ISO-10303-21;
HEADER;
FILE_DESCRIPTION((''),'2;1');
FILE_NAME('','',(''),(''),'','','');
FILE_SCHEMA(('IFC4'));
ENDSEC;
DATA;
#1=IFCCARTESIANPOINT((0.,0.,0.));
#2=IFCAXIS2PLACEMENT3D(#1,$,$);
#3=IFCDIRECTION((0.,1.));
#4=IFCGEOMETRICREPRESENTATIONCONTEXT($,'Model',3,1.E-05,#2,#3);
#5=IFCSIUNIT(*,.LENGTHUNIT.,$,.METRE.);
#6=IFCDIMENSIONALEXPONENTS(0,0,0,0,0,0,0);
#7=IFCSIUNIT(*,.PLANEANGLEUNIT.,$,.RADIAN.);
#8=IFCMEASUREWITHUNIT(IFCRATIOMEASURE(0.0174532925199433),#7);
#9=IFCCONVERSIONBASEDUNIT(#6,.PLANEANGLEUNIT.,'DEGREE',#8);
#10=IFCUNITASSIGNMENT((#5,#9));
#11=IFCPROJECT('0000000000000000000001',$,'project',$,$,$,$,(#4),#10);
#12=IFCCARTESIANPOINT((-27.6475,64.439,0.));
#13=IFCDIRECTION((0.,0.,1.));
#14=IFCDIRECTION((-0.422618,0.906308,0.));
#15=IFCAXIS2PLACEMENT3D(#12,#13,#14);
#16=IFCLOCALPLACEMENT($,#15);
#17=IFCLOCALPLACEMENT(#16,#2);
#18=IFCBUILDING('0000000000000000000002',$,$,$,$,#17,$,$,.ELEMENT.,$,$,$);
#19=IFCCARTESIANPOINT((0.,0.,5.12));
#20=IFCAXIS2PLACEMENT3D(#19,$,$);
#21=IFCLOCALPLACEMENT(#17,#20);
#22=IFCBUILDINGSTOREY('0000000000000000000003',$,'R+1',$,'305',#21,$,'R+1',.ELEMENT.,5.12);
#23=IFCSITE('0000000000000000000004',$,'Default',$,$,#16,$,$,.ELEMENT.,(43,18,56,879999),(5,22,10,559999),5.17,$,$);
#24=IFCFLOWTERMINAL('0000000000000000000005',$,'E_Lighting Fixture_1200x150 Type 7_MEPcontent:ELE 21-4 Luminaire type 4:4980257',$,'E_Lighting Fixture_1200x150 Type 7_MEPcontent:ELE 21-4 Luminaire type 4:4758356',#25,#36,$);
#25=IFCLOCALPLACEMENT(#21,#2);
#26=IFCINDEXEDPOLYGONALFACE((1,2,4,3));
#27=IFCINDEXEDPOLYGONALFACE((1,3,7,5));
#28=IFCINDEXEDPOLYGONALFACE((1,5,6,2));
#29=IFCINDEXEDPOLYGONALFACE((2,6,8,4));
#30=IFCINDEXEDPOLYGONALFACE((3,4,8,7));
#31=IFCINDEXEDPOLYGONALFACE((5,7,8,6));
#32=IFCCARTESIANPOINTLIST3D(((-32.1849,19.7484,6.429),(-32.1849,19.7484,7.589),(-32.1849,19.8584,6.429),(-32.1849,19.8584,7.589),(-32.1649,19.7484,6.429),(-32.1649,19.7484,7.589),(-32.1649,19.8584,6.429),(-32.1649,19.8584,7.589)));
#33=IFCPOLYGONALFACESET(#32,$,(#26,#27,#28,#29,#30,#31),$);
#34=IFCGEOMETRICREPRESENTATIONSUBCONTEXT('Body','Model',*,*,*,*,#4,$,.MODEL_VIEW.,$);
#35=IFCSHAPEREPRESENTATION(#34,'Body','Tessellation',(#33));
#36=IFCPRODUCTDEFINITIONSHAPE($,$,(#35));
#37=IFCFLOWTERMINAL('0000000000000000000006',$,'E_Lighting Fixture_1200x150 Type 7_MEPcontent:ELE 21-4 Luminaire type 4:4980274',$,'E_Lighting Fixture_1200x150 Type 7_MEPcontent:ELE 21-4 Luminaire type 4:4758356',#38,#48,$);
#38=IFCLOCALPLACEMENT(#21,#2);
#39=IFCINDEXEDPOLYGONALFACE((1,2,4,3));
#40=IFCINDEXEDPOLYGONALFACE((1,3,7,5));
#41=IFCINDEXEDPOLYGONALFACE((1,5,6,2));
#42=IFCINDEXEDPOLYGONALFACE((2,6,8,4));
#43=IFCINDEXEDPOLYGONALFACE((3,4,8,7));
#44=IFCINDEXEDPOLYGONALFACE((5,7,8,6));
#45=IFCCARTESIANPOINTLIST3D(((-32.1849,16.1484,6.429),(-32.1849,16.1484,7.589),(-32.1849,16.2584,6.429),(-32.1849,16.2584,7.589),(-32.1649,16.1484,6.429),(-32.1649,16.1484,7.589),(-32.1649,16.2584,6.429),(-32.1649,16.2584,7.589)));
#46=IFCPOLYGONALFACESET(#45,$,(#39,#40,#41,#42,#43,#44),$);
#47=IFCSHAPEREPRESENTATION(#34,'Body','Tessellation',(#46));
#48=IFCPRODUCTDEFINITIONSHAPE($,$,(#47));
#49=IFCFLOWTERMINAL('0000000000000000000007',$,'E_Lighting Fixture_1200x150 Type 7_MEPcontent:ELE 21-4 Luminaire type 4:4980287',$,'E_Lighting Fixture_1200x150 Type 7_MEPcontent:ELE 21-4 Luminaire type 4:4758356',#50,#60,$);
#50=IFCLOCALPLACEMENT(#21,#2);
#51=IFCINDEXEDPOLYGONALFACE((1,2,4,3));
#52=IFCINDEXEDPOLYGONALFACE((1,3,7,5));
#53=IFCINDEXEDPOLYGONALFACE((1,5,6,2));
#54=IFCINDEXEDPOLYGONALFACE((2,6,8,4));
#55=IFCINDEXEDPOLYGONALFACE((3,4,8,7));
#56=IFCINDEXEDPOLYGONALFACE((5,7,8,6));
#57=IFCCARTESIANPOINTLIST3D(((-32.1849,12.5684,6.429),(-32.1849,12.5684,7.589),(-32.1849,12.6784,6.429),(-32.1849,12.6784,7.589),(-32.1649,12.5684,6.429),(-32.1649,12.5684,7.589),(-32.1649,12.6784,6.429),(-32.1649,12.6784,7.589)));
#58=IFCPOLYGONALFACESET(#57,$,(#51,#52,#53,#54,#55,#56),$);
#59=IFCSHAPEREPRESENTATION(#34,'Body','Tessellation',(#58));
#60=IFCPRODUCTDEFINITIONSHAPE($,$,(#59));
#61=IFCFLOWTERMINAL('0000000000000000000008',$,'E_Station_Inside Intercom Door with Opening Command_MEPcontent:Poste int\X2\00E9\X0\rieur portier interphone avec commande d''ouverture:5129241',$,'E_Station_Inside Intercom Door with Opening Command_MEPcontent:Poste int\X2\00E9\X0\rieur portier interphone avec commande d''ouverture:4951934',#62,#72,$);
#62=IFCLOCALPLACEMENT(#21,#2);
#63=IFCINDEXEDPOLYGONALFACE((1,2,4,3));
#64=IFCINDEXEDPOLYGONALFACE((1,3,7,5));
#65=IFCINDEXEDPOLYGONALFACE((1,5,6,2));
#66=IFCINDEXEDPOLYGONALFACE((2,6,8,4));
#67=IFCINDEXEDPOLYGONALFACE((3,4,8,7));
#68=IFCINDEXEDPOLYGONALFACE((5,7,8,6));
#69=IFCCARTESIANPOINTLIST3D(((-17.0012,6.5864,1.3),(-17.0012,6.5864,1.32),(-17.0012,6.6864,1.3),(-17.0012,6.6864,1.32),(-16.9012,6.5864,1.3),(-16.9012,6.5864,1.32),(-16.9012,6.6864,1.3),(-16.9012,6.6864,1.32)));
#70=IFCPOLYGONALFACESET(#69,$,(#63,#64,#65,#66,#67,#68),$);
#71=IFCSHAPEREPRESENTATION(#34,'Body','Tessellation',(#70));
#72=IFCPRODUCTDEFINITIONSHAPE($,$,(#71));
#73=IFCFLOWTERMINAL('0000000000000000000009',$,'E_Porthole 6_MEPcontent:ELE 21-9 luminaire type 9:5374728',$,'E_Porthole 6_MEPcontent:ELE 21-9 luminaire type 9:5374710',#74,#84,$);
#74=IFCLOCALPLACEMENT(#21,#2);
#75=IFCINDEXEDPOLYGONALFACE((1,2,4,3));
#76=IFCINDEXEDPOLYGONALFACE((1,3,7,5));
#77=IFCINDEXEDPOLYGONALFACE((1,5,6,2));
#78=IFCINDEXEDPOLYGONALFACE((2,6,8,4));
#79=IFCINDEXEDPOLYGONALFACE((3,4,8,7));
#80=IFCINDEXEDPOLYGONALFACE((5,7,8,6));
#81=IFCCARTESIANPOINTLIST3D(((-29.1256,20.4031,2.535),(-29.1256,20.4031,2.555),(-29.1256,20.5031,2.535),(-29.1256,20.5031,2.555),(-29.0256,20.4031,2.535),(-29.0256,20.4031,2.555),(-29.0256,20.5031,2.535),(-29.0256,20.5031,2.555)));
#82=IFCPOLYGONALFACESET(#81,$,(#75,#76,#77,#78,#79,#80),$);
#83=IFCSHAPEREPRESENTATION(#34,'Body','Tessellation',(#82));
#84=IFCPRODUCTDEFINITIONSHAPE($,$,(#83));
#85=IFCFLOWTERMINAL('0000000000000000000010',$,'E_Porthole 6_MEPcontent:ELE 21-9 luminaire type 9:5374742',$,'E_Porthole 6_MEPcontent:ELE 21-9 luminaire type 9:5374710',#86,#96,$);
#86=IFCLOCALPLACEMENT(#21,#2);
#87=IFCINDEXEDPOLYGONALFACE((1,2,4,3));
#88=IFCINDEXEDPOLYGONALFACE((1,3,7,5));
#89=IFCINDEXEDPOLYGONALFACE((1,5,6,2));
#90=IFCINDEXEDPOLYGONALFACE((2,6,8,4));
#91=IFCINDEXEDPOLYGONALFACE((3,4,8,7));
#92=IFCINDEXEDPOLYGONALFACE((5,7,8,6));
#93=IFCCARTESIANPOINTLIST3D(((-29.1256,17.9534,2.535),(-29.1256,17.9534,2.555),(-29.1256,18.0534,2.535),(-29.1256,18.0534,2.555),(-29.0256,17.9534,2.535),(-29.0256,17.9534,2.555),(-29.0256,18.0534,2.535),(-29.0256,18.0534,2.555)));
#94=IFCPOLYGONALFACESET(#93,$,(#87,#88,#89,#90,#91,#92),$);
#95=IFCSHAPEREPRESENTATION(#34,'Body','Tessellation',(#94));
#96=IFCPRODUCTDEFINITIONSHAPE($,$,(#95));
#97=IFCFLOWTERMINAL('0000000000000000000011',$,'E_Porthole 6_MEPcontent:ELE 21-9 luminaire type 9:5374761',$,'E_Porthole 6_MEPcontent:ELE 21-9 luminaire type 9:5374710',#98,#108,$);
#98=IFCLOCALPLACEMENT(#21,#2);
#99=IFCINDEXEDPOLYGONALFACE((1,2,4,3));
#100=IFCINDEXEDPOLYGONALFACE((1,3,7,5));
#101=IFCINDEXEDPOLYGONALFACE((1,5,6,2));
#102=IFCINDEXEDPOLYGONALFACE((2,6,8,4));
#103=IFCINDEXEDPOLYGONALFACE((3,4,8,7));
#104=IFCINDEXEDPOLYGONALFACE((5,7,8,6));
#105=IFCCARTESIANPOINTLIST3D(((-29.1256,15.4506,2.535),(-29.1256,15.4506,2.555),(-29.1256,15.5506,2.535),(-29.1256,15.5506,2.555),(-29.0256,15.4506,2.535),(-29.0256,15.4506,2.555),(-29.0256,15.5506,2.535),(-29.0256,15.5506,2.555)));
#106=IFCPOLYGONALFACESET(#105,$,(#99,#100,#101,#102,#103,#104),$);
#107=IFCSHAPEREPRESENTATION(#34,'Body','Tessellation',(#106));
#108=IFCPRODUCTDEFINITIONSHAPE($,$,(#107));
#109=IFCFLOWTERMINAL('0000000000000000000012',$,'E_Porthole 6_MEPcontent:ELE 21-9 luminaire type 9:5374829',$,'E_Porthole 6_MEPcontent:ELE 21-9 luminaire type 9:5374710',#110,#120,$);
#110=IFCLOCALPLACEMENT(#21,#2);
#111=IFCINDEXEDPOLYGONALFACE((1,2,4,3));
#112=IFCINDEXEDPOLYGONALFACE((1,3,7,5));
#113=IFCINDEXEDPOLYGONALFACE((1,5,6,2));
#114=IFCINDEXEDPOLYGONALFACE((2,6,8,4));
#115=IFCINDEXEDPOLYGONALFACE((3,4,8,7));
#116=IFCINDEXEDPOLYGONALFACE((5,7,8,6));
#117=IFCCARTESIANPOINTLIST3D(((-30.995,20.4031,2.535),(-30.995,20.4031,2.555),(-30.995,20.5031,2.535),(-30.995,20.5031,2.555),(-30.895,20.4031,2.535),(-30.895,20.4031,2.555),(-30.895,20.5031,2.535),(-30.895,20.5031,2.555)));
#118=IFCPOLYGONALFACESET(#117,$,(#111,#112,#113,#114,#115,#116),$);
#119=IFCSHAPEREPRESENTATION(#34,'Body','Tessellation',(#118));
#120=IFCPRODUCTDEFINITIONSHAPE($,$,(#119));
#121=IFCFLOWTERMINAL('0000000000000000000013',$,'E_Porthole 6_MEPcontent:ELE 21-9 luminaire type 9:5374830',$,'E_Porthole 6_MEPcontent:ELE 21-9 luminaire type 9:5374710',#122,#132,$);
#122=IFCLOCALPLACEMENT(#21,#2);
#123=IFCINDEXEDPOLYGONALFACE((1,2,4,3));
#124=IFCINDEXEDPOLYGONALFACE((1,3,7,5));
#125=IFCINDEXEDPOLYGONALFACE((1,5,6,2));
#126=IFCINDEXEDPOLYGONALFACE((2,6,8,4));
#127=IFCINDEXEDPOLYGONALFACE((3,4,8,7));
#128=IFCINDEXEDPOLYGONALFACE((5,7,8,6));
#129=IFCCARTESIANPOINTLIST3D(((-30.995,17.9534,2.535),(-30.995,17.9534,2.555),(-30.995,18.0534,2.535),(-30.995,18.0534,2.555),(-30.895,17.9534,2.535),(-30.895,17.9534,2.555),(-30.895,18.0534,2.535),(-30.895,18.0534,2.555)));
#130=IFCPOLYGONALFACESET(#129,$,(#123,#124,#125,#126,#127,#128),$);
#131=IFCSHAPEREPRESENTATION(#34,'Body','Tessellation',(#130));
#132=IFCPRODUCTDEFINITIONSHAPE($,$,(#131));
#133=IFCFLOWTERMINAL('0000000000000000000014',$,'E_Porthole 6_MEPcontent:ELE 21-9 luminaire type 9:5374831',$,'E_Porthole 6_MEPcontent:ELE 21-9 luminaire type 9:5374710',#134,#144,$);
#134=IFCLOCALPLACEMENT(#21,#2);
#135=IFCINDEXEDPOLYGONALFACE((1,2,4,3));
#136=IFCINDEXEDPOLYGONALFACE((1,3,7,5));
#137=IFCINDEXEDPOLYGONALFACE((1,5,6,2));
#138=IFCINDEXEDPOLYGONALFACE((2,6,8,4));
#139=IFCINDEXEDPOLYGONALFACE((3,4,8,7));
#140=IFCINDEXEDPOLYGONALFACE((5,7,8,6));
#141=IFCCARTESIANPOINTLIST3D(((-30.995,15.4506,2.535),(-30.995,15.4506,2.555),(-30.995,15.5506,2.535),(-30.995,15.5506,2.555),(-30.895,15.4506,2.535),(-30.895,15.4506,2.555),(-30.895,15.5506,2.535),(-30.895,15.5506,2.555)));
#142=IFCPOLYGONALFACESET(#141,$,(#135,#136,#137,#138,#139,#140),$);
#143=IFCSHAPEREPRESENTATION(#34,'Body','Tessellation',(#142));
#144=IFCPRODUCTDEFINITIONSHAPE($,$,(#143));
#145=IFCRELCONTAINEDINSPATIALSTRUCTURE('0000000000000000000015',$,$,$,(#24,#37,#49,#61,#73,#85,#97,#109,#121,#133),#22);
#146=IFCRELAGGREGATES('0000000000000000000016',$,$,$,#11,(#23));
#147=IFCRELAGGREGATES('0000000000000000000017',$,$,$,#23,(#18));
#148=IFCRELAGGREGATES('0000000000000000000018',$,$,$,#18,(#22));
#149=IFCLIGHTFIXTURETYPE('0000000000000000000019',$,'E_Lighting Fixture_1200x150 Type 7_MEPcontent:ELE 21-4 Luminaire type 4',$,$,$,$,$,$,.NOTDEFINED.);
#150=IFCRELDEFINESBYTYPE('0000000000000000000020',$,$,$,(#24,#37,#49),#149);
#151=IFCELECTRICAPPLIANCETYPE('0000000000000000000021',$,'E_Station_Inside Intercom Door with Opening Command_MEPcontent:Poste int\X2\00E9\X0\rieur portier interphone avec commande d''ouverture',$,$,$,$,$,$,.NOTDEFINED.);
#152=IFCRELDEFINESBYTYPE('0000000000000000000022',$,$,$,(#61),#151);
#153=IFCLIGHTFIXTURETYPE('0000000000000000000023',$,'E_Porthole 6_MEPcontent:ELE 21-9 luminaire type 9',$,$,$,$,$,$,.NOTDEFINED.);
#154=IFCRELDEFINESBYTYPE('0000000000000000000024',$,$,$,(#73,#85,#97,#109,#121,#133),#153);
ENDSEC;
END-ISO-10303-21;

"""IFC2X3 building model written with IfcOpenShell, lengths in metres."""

from ifc_helpers import new_model, entity, si_unit, converted_unit, direction, frame, frame_2d, origin, origin_2d_with_axis, place, context, subcontext, project, spatial, rectangle, extrude, source, transform, mapped, type_object, type_shapes, element, save


model = new_model("IFC2X3")

# Units and contexts
model_context = context("Model", 3, precision=1e-05, world=origin(), true_north=direction((0.0, 1.0)))
body_context = subcontext(model_context, "Body", "Model", "MODEL_VIEW")
ifc_project = project(units=[si_unit("LENGTHUNIT", "METRE"), converted_unit("PLANEANGLEUNIT", "DEGREE", entity("IfcRatioMeasure", 0.0174532925199433), si_unit("PLANEANGLEUNIT", "RADIAN"), dimensions=[0, 0, 0, 0, 0, 0, 0])], contexts=[model_context])

# Site, building, storey
site_placement = place(None, frame((-27.6475, 64.439, 0.0), z_axis=(0.0, 0.0, 1.0), x_axis=(-0.422618, 0.906308, 0.0)))
site = spatial("IfcSite", under=ifc_project, at=site_placement, Name="Default", CompositionType="ELEMENT", RefLatitude=(43, 18, 56, 879999), RefLongitude=(5, 22, 10, 559999), RefElevation=5.17)
building_placement = place(site_placement, origin())
building = spatial("IfcBuilding", under=site, at=building_placement, CompositionType="ELEMENT")
storey_placement = place(building_placement, frame((0.0, 0.0, 5.12)))
storey = spatial("IfcBuildingStorey", under=building, at=storey_placement, Name="R+1", ObjectType="305", LongName="R+1", CompositionType="ELEMENT", Elevation=5.12)

# Flow terminals
light_fixture_type_1 = type_object("IfcLightFixtureType", Name="E_Lighting Fixture_1200x150 Type 7_MEPcontent:ELE 21-4 Luminaire type 4", PredefinedType="NOTDEFINED")
shared_shape_1 = source(origin(), body_context, "Body", "SweptSolid", [
    extrude(rectangle(XDim=0.02, YDim=0.11, at=frame_2d((0.0, 0.0), x_axis=(1.0, 0.0))), frame((0.01, 0.0, -0.58), z_axis=(0.0, 0.0, 1.0), x_axis=(-1.0, 0.0, 0.0)), (0.0, 0.0, 1.0), 1.16),
])
type_shapes(light_fixture_type_1, [shared_shape_1])
for number, where, name in (
    (1, (-32.1849, 19.8034, 7.009), "E_Lighting Fixture_1200x150 Type 7_MEPcontent:ELE 21-4 Luminaire type 4:4980257"),
    (2, (-32.1849, 16.2034, 7.009), "E_Lighting Fixture_1200x150 Type 7_MEPcontent:ELE 21-4 Luminaire type 4:4980274"),
    (3, (-32.1849, 12.6234, 7.009), "E_Lighting Fixture_1200x150 Type 7_MEPcontent:ELE 21-4 Luminaire type 4:4980287"),
):
    element("IfcFlowTerminal", number, at=place(storey_placement, frame(where)), inside=storey, type_object=light_fixture_type_1, Name=name, ObjectType="E_Lighting Fixture_1200x150 Type 7_MEPcontent:ELE 21-4 Luminaire type 4:4758356", context=body_context, shape_type="MappedRepresentation", body=[
        mapped(shared_shape_1, transform((0.0, 0.0, 0.0), scale=1.0)),
    ])
electric_appliance_type = type_object("IfcElectricApplianceType", Name="E_Station_Inside Intercom Door with Opening Command_MEPcontent:Poste intérieur portier interphone avec commande d'ouverture", PredefinedType="NOTDEFINED")
shared_shape_2 = source(origin(), body_context, "Body", "SweptSolid", [
    extrude(rectangle(XDim=0.1, YDim=0.1, at=origin_2d_with_axis()), frame((0.0, 0.0, 0.0), z_axis=(0.0, 0.0, 1.0), x_axis=(0.0, -1.0, 0.0)), (0.0, 0.0, 1.0), 0.02),
])
type_shapes(electric_appliance_type, [shared_shape_2])
flow_terminal_placement = place(storey_placement, frame((-16.9512, 6.6364, 1.3), z_axis=(0.0, 0.0, 1.0), x_axis=(-1.0, 0.0, 0.0)))
element("IfcFlowTerminal", 4, at=flow_terminal_placement, inside=storey, type_object=electric_appliance_type, Name="E_Station_Inside Intercom Door with Opening Command_MEPcontent:Poste intérieur portier interphone avec commande d'ouverture:5129241", ObjectType="E_Station_Inside Intercom Door with Opening Command_MEPcontent:Poste intérieur portier interphone avec commande d'ouverture:4951934", context=body_context, shape_type="MappedRepresentation", body=[
    mapped(shared_shape_2, transform((0.0, 0.0, 0.0), scale=1.0)),
])
light_fixture_type_2 = type_object("IfcLightFixtureType", Name="E_Porthole 6_MEPcontent:ELE 21-9 luminaire type 9", PredefinedType="NOTDEFINED")
shared_shape_3 = source(origin(), body_context, "Body", "SweptSolid", [
    extrude(rectangle(XDim=0.1, YDim=0.1, at=origin_2d_with_axis()), frame((0.0, 0.0, 0.0), z_axis=(0.0, 0.0, 1.0), x_axis=(0.0, -1.0, 0.0)), (0.0, 0.0, 1.0), 0.02),
])
type_shapes(light_fixture_type_2, [shared_shape_3])
for number, where, z_axis, x_axis, name in (
    (5, (-29.0756, 20.4531, 2.535), (0.0, 0.0, 1.0), (0.0, -1.0, 0.0), "E_Porthole 6_MEPcontent:ELE 21-9 luminaire type 9:5374728"),
    (6, (-29.0756, 18.0034, 2.535), (0.0, 0.0, 1.0), (0.0, -1.0, 0.0), "E_Porthole 6_MEPcontent:ELE 21-9 luminaire type 9:5374742"),
    (7, (-29.0756, 15.5006, 2.535), (0.0, 0.0, 1.0), (0.0, -1.0, 0.0), "E_Porthole 6_MEPcontent:ELE 21-9 luminaire type 9:5374761"),
    (8, (-30.945, 20.4531, 2.535), (0.0, 0.0, 1.0), (0.0, -1.0, 0.0), "E_Porthole 6_MEPcontent:ELE 21-9 luminaire type 9:5374829"),
    (9, (-30.945, 18.0034, 2.535), (0.0, 0.0, 1.0), (0.0, -1.0, 0.0), "E_Porthole 6_MEPcontent:ELE 21-9 luminaire type 9:5374830"),
    (10, (-30.945, 15.5006, 2.535), (0.0, 0.0, 1.0), (0.0, -1.0, 0.0), "E_Porthole 6_MEPcontent:ELE 21-9 luminaire type 9:5374831"),
):
    element("IfcFlowTerminal", number, at=place(storey_placement, frame(where, z_axis=z_axis, x_axis=x_axis)), inside=storey, type_object=light_fixture_type_2, Name=name, ObjectType="E_Porthole 6_MEPcontent:ELE 21-9 luminaire type 9:5374710", context=body_context, shape_type="MappedRepresentation", body=[
        mapped(shared_shape_3, transform((0.0, 0.0, 0.0), scale=1.0)),
    ])

save(model, "model.ifc")
